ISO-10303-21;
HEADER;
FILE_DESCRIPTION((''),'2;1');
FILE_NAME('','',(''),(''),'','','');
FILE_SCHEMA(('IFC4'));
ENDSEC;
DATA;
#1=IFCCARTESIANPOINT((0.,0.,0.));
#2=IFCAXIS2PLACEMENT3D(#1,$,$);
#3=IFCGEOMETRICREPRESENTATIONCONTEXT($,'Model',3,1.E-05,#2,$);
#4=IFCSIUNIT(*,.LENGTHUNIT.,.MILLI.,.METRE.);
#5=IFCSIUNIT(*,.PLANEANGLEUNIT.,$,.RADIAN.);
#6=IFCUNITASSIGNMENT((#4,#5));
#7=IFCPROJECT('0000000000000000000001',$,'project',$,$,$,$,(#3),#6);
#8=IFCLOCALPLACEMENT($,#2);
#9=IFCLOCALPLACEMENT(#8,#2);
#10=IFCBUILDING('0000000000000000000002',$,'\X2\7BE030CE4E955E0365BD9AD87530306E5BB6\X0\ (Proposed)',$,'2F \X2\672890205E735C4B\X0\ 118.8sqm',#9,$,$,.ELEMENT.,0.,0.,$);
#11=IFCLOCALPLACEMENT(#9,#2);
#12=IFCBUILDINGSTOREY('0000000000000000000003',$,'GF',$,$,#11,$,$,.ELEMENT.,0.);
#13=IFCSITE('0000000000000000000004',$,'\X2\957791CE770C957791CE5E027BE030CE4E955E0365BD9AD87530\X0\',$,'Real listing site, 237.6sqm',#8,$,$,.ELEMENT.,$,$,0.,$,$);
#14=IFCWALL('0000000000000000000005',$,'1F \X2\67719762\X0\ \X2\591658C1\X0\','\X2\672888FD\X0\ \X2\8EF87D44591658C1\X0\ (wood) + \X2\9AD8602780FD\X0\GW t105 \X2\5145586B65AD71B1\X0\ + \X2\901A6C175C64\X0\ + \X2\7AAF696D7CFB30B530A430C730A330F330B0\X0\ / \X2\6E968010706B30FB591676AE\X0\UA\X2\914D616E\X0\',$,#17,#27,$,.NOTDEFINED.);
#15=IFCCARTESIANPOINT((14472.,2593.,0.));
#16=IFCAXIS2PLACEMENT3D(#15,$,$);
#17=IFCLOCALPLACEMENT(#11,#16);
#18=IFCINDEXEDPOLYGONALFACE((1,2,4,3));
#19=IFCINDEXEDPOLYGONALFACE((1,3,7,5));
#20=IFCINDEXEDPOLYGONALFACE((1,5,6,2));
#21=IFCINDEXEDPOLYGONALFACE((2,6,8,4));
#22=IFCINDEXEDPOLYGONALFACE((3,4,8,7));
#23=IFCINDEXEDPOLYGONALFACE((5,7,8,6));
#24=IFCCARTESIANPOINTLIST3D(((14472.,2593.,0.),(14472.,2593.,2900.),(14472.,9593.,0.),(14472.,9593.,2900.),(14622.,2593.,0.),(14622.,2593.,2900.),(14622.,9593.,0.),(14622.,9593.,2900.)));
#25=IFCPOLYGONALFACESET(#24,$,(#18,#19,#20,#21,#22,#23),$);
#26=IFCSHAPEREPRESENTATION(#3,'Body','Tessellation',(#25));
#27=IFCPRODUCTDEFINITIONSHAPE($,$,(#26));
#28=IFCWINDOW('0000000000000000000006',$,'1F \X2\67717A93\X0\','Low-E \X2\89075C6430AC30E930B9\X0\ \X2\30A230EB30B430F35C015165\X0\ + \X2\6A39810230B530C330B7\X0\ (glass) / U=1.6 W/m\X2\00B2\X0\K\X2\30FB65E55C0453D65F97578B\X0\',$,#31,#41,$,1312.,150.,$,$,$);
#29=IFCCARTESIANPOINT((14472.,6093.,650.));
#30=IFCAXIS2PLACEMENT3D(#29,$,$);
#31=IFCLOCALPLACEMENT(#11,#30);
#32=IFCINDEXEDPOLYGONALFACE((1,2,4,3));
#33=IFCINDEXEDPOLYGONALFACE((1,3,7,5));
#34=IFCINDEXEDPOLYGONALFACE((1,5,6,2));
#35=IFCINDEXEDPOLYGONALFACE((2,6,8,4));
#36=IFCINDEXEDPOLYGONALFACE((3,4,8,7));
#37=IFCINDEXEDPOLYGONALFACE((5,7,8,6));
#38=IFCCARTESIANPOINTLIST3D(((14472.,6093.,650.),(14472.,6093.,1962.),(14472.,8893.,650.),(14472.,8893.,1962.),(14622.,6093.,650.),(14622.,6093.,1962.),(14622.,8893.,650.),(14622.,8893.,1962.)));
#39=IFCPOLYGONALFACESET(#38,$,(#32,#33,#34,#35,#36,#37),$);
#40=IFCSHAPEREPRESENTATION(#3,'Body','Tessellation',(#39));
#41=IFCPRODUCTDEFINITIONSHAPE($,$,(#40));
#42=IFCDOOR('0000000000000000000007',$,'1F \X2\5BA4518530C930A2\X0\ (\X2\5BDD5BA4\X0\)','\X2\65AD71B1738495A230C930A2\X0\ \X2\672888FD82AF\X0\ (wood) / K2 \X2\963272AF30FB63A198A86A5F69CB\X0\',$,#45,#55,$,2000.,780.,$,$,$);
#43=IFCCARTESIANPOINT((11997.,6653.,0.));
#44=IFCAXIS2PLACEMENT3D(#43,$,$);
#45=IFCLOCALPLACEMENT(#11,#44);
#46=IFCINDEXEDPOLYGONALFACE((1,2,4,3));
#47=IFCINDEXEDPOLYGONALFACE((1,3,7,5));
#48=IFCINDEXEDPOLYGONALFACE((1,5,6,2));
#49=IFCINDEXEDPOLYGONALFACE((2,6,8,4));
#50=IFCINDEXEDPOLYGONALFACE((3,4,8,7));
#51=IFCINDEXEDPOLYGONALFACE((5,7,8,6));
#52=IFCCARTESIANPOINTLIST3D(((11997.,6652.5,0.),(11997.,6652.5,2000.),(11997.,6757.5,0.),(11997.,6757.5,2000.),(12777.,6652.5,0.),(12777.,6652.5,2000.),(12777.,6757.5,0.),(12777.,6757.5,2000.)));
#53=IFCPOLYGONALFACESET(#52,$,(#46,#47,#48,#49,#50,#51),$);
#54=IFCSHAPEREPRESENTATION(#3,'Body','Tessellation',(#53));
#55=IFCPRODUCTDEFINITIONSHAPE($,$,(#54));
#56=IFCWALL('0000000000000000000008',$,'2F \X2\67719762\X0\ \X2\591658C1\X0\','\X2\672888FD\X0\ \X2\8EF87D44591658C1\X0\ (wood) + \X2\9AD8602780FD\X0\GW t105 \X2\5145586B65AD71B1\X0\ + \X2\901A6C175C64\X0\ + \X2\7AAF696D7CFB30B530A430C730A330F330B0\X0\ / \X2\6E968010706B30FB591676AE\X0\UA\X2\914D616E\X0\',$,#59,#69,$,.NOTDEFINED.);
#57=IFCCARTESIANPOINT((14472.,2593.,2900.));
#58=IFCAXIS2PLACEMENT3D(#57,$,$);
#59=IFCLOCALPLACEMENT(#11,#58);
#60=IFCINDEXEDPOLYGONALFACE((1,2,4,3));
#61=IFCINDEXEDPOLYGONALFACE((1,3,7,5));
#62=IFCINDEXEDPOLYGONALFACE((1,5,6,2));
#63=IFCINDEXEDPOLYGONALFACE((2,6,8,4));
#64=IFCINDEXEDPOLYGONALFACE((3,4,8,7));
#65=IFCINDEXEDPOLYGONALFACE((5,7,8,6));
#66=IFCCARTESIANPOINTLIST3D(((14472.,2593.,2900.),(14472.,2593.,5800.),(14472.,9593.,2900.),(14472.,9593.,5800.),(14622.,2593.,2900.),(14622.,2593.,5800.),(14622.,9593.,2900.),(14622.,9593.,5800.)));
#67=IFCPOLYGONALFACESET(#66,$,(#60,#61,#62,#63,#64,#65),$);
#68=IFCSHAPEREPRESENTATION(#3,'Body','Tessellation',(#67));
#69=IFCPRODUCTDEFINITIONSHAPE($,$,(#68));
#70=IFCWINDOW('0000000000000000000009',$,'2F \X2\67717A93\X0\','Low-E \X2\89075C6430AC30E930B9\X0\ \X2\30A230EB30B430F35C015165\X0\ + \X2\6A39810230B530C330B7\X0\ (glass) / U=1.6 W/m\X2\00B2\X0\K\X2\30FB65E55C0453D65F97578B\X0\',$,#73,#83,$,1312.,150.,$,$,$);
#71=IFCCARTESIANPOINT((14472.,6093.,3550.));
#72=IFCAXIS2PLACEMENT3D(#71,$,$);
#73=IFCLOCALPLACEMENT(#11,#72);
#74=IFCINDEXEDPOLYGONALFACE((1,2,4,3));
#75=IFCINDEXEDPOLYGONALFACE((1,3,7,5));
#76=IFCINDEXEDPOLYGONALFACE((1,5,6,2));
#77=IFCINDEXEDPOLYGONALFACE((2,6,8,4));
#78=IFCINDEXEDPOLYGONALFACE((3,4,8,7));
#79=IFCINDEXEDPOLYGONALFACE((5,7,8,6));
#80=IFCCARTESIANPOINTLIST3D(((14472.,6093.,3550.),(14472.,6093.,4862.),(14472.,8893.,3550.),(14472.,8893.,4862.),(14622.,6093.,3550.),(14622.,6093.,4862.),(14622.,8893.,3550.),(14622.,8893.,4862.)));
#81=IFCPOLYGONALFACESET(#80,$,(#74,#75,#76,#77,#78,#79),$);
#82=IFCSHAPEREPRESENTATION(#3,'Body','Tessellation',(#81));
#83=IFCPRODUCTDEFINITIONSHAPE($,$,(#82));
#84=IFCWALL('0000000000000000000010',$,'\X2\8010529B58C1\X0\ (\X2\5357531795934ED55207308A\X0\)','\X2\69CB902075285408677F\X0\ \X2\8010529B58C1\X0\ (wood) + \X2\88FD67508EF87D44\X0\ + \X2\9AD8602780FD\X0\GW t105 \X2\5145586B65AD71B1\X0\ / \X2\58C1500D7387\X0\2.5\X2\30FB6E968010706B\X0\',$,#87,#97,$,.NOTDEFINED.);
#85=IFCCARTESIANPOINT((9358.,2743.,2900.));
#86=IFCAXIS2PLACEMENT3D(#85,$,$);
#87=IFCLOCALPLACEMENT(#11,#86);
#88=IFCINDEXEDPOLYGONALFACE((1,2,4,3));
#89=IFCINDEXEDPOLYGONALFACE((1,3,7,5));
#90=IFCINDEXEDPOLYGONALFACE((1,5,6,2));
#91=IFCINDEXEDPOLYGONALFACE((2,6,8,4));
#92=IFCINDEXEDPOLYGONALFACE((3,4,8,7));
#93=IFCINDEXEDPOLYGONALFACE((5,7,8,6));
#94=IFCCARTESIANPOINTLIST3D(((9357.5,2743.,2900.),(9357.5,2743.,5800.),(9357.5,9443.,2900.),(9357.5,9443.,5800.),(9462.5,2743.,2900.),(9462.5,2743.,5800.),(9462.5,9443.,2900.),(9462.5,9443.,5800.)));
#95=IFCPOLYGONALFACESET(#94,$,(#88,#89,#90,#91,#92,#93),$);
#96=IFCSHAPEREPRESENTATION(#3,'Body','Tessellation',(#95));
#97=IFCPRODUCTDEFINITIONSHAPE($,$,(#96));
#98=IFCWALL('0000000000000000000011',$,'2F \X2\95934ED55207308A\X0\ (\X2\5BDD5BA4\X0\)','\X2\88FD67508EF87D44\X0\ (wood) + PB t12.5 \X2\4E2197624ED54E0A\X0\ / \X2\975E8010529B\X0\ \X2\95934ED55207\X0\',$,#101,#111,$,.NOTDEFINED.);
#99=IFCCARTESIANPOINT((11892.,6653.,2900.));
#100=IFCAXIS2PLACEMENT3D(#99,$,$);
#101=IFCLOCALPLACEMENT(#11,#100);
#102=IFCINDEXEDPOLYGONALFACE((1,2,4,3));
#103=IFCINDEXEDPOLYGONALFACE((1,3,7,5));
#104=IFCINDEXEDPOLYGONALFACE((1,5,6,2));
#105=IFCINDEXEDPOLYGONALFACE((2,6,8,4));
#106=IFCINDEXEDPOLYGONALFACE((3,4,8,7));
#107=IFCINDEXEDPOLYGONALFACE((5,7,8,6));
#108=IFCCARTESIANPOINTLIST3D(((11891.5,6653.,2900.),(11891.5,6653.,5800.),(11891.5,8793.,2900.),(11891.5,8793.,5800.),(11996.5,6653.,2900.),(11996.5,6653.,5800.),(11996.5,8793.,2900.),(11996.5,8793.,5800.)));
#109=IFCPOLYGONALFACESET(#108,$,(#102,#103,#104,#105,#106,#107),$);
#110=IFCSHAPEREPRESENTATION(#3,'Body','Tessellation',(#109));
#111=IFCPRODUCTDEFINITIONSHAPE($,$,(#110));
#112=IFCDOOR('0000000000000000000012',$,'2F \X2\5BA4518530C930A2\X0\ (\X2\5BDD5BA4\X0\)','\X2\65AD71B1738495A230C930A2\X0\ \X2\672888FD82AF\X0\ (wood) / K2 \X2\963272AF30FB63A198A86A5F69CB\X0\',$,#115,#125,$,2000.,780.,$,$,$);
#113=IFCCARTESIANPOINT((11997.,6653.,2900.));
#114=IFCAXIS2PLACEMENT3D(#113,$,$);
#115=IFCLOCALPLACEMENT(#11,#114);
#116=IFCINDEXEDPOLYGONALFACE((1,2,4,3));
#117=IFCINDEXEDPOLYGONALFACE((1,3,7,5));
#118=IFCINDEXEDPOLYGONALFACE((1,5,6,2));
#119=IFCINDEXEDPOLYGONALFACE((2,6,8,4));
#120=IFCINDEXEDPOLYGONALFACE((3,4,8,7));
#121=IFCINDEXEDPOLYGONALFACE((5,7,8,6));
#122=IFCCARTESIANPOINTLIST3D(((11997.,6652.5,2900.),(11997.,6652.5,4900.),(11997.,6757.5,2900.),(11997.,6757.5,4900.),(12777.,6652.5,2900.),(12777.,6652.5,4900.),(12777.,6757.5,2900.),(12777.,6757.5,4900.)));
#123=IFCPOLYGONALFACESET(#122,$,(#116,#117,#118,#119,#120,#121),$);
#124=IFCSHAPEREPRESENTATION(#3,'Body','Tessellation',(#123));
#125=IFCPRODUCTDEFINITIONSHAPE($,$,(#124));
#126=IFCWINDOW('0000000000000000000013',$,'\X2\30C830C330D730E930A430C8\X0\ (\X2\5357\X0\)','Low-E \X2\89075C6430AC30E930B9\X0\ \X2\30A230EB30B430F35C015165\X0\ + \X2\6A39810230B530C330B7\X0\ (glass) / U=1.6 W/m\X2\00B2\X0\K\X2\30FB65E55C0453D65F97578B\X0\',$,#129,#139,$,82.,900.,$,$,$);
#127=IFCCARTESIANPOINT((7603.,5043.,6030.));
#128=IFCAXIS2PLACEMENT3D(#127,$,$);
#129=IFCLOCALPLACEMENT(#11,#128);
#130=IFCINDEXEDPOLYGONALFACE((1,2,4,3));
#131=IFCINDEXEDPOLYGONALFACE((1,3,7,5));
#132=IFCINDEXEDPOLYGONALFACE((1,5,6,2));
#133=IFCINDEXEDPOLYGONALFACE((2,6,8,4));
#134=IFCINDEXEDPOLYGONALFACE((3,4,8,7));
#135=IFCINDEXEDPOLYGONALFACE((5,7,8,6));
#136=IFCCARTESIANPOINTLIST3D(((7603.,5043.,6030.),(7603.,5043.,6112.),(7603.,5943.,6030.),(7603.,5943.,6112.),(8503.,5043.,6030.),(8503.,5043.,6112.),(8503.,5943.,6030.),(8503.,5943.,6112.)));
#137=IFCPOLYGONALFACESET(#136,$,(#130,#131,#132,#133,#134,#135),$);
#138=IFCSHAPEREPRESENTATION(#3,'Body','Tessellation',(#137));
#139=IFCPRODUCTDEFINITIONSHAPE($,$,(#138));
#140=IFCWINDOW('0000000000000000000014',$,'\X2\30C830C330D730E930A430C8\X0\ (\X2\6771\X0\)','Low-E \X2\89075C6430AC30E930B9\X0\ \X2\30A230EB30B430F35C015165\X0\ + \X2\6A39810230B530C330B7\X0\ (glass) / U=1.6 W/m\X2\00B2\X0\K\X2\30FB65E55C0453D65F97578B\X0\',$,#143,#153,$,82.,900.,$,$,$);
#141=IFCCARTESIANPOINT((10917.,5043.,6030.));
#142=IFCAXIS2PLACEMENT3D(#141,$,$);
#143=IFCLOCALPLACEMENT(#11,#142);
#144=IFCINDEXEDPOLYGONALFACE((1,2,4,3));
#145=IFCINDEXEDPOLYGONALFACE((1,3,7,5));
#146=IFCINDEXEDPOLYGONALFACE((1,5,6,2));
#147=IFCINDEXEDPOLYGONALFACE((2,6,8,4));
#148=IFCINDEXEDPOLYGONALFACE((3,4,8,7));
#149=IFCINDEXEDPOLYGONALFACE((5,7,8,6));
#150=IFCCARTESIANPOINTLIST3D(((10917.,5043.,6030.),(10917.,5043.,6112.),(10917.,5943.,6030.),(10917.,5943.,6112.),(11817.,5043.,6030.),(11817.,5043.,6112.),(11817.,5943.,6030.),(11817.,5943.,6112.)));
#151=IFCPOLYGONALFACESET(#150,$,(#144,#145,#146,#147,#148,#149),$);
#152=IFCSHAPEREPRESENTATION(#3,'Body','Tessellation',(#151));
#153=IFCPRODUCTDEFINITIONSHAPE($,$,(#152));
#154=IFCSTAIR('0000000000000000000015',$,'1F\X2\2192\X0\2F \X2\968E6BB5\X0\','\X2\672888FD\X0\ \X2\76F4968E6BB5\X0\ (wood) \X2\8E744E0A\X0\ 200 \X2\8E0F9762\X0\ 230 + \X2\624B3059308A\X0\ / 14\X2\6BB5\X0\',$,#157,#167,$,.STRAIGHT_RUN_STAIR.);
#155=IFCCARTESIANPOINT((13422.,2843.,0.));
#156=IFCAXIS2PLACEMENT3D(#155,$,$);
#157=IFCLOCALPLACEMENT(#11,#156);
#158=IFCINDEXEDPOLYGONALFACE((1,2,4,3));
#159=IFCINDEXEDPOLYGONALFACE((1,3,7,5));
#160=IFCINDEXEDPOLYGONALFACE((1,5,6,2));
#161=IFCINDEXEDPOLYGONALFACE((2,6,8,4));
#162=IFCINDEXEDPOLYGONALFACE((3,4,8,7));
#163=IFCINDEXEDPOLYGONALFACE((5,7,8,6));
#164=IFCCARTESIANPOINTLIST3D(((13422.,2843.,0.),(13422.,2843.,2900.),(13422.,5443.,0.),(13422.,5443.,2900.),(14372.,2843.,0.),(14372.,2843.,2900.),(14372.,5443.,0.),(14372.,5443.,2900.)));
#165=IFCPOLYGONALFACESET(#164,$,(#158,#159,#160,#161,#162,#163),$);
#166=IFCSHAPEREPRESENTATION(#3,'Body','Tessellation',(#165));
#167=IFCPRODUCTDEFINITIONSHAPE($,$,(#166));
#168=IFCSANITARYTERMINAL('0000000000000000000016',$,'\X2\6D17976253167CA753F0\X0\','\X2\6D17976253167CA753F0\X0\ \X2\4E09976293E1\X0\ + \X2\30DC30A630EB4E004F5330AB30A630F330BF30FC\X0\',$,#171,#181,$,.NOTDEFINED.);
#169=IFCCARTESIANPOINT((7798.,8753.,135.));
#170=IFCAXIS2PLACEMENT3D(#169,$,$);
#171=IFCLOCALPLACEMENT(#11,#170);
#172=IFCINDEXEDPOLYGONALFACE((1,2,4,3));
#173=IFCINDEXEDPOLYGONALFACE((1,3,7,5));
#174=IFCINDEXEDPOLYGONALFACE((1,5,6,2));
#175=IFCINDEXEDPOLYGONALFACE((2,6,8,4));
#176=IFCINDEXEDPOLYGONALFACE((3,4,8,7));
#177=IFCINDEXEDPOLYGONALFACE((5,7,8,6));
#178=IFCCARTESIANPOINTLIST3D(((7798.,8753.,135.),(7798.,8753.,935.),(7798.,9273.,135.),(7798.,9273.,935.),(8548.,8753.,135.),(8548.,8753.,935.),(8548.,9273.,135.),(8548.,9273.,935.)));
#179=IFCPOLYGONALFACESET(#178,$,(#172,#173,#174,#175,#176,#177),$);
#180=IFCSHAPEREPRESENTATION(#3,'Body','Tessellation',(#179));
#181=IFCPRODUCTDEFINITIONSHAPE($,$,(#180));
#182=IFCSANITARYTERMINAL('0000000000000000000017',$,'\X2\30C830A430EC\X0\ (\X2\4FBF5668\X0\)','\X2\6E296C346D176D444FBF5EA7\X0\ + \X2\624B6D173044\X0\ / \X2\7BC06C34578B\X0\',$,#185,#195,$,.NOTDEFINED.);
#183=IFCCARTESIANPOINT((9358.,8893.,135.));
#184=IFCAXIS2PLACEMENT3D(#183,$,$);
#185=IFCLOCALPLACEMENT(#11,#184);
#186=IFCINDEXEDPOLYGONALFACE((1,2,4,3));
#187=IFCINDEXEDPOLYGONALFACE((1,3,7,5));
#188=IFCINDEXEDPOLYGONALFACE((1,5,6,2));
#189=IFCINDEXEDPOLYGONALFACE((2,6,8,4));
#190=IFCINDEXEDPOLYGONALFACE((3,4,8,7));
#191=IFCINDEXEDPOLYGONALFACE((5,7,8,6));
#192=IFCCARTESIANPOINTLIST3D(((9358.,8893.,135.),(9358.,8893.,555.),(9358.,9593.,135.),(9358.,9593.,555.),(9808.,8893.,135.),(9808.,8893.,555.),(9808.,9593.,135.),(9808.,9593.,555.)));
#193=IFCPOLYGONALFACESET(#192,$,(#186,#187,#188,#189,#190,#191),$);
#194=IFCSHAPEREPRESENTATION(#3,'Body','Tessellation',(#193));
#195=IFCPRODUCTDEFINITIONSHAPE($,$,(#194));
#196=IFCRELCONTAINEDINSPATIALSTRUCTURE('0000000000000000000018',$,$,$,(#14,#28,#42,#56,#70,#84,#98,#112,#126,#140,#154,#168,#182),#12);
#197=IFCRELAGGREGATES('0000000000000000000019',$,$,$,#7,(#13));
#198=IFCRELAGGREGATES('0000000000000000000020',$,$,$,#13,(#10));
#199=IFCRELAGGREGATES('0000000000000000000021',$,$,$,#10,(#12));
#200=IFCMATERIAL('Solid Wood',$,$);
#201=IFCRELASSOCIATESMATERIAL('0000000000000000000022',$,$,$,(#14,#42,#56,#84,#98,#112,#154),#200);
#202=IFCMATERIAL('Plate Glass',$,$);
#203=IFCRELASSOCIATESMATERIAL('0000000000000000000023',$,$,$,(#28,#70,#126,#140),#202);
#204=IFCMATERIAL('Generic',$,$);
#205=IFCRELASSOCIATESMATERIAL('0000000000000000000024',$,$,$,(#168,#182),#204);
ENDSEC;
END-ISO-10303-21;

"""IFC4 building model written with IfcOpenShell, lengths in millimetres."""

from ifc_helpers import new_model, si_unit, frame, frame_2d, origin, place, context, project, spatial, rectangle, extrude, material, element, fill, save


model = new_model("IFC4")

# Units and contexts
model_context = context("Model", 3, precision=1e-05, world=origin())
ifc_project = project(units=[si_unit("LENGTHUNIT", "METRE", prefix="MILLI"), si_unit("PLANEANGLEUNIT", "RADIAN")], contexts=[model_context])

# Site, building, storey
site_placement = place(None, origin())
site = spatial("IfcSite", under=ifc_project, at=site_placement, Name="長野県長野市篠ノ井布施高田", ObjectType="Real listing site, 237.6sqm", CompositionType="ELEMENT", RefElevation=0.0)
building_placement = place(site_placement, origin())
building = spatial("IfcBuilding", under=site, at=building_placement, Name="篠ノ井布施高田の家 (Proposed)", ObjectType="2F 木造平屋 118.8sqm", CompositionType="ELEMENT", ElevationOfRefHeight=0.0, ElevationOfTerrain=0.0)
storey_placement = place(building_placement, origin())
storey = spatial("IfcBuildingStorey", under=building, at=storey_placement, Name="GF", CompositionType="ELEMENT", Elevation=0.0)

# Wall, opening, window
ifc_material_1 = material(Name="Solid Wood")
wall_1_placement = place(storey_placement, frame((14472.0, 2593.0, 0.0)))
wall_1 = element("IfcWall", 1, at=wall_1_placement, inside=storey, material=ifc_material_1, Name="1F 東面 外壁", Description="木製 軸組外壁 (wood) + 高性能GW t105 充填断熱 + 通気層 + 窯業系サイディング / 準耐火・外皮UA配慮", PredefinedType="NOTDEFINED", context=model_context, shape_type="SweptSolid", body=[
    extrude(rectangle(XDim=150.0, YDim=7000.0, at=frame_2d((75.0, 3500.0))), frame((14472.0, 2593.0, 0.0)), (0.0, 0.0, 1.0), 2900.0),
])
opening_1_placement = place(storey_placement, frame((14472.0, 6093.0, 650.0)))
opening_1 = element("IfcOpeningElement", 2, at=opening_1_placement, cuts=wall_1, PredefinedType="NOTDEFINED", context=model_context, shape_type="SweptSolid", body=[
    extrude(rectangle(XDim=150.0, YDim=2800.0, at=frame_2d((75.0, 1400.0))), frame((14472.0, 6093.0, 650.0)), (0.0, 0.0, 1.0), 1312.0),
])
ifc_material_2 = material(Name="Plate Glass")
window_1_placement = place(storey_placement, frame((14472.0, 6093.0, 650.0)))
window_1 = element("IfcWindow", 3, at=window_1_placement, inside=storey, material=ifc_material_2, Name="1F 東窓", Description="Low-E 複層ガラス アルゴン封入 + 樹脂サッシ (glass) / U=1.6 W/m²K・日射取得型", OverallHeight=1312.0, OverallWidth=150.0, context=model_context, shape_type="SweptSolid", body=[
    extrude(rectangle(XDim=150.0, YDim=2800.0, at=frame_2d((75.0, 1400.0))), frame((14472.0, 6093.0, 650.0)), (0.0, 0.0, 1.0), 1312.0),
])
fill(opening_1, window_1)

# Door
door_1_placement = place(storey_placement, frame((11997.0, 6653.0, 0.0)))
element("IfcDoor", 4, at=door_1_placement, inside=storey, material=ifc_material_1, Name="1F 室内ドア (寝室)", Description="断熱玄関ドア 木製芯 (wood) / K2 防犯・採風機構", OverallHeight=2000.0, OverallWidth=780.0, context=model_context, shape_type="SweptSolid", body=[
    extrude(rectangle(XDim=780.0, YDim=105.0, at=frame_2d((390.0, 52.0))), frame((11997.0, 6653.0, 0.0)), (0.0, 0.0, 1.0), 2000.0),
])

# Wall, opening, window
wall_2_placement = place(storey_placement, frame((14472.0, 2593.0, 2900.0)))
wall_2 = element("IfcWall", 5, at=wall_2_placement, inside=storey, material=ifc_material_1, Name="2F 東面 外壁", Description="木製 軸組外壁 (wood) + 高性能GW t105 充填断熱 + 通気層 + 窯業系サイディング / 準耐火・外皮UA配慮", PredefinedType="NOTDEFINED", context=model_context, shape_type="SweptSolid", body=[
    extrude(rectangle(XDim=150.0, YDim=7000.0, at=frame_2d((75.0, 3500.0))), frame((14472.0, 2593.0, 2900.0)), (0.0, 0.0, 1.0), 2900.0),
])
opening_2_placement = place(storey_placement, frame((14472.0, 6093.0, 3550.0)))
opening_2 = element("IfcOpeningElement", 6, at=opening_2_placement, cuts=wall_2, PredefinedType="NOTDEFINED", context=model_context, shape_type="SweptSolid", body=[
    extrude(rectangle(XDim=150.0, YDim=2800.0, at=frame_2d((75.0, 1400.0))), frame((14472.0, 6093.0, 3550.0)), (0.0, 0.0, 1.0), 1312.0),
])
window_2_placement = place(storey_placement, frame((14472.0, 6093.0, 3550.0)))
window_2 = element("IfcWindow", 7, at=window_2_placement, inside=storey, material=ifc_material_2, Name="2F 東窓", Description="Low-E 複層ガラス アルゴン封入 + 樹脂サッシ (glass) / U=1.6 W/m²K・日射取得型", OverallHeight=1312.0, OverallWidth=150.0, context=model_context, shape_type="SweptSolid", body=[
    extrude(rectangle(XDim=150.0, YDim=2800.0, at=frame_2d((75.0, 1400.0))), frame((14472.0, 6093.0, 3550.0)), (0.0, 0.0, 1.0), 1312.0),
])
fill(opening_2, window_2)

# Walls
wall_3_placement = place(storey_placement, frame((9358.0, 2743.0, 2900.0)))
element("IfcWall", 8, at=wall_3_placement, inside=storey, material=ifc_material_1, Name="耐力壁 (南北間仕切り)", Description="構造用合板 耐力壁 (wood) + 製材軸組 + 高性能GW t105 充填断熱 / 壁倍率2.5・準耐火", PredefinedType="NOTDEFINED", context=model_context, shape_type="SweptSolid", body=[
    extrude(rectangle(XDim=105.0, YDim=6700.0, at=frame_2d((52.0, 3350.0))), frame((9358.0, 2743.0, 2900.0)), (0.0, 0.0, 1.0), 2900.0),
])
wall_4_placement = place(storey_placement, frame((11892.0, 6653.0, 2900.0)))
element("IfcWall", 9, at=wall_4_placement, inside=storey, material=ifc_material_1, Name="2F 間仕切り (寝室)", Description="製材軸組 (wood) + PB t12.5 両面仕上 / 非耐力 間仕切", PredefinedType="NOTDEFINED", context=model_context, shape_type="SweptSolid", body=[
    extrude(rectangle(XDim=105.0, YDim=2140.0, at=frame_2d((52.0, 1070.0))), frame((11892.0, 6653.0, 2900.0)), (0.0, 0.0, 1.0), 2900.0),
])

# Door
door_2_placement = place(storey_placement, frame((11997.0, 6653.0, 2900.0)))
element("IfcDoor", 10, at=door_2_placement, inside=storey, material=ifc_material_1, Name="2F 室内ドア (寝室)", Description="断熱玄関ドア 木製芯 (wood) / K2 防犯・採風機構", OverallHeight=2000.0, OverallWidth=780.0, context=model_context, shape_type="SweptSolid", body=[
    extrude(rectangle(XDim=780.0, YDim=105.0, at=frame_2d((390.0, 52.0))), frame((11997.0, 6653.0, 2900.0)), (0.0, 0.0, 1.0), 2000.0),
])

# Windows
window_3_placement = place(storey_placement, frame((7603.0, 5043.0, 6030.0)))
element("IfcWindow", 11, at=window_3_placement, inside=storey, material=ifc_material_2, Name="トップライト (南)", Description="Low-E 複層ガラス アルゴン封入 + 樹脂サッシ (glass) / U=1.6 W/m²K・日射取得型", OverallHeight=82.0, OverallWidth=900.0, context=model_context, shape_type="SweptSolid", body=[
    extrude(rectangle(XDim=900.0, YDim=900.0, at=frame_2d((450.0, 450.0))), frame((7603.0, 5043.0, 6030.0)), (0.0, 0.0, 1.0), 82.0),
])
window_4_placement = place(storey_placement, frame((10917.0, 5043.0, 6030.0)))
element("IfcWindow", 12, at=window_4_placement, inside=storey, material=ifc_material_2, Name="トップライト (東)", Description="Low-E 複層ガラス アルゴン封入 + 樹脂サッシ (glass) / U=1.6 W/m²K・日射取得型", OverallHeight=82.0, OverallWidth=900.0, context=model_context, shape_type="SweptSolid", body=[
    extrude(rectangle(XDim=900.0, YDim=900.0, at=frame_2d((450.0, 450.0))), frame((10917.0, 5043.0, 6030.0)), (0.0, 0.0, 1.0), 82.0),
])

# Stair
stair_placement = place(storey_placement, frame((13422.0, 2843.0, 0.0)))
element("IfcStair", 13, at=stair_placement, inside=storey, material=ifc_material_1, Name="1F→2F 階段", Description="木製 直階段 (wood) 蹴上 200 踏面 230 + 手すり / 14段", PredefinedType="STRAIGHT_RUN_STAIR", context=model_context, shape_type="SweptSolid", body=[
    extrude(rectangle(XDim=950.0, YDim=2600.0, at=frame_2d((475.0, 1300.0))), frame((13422.0, 2843.0, 0.0)), (0.0, 0.0, 1.0), 2900.0),
])

# Sanitary terminals
ifc_material_3 = material(Name="Generic")
sanitary_terminal_1_placement = place(storey_placement, frame((7798.0, 8753.0, 135.0)))
element("IfcSanitaryTerminal", 14, at=sanitary_terminal_1_placement, inside=storey, material=ifc_material_3, Name="洗面化粧台", Description="洗面化粧台 三面鏡 + ボウル一体カウンター", PredefinedType="NOTDEFINED", context=model_context, shape_type="SweptSolid", body=[
    extrude(rectangle(XDim=750.0, YDim=520.0, at=frame_2d((375.0, 260.0))), frame((7798.0, 8753.0, 135.0)), (0.0, 0.0, 1.0), 800.0),
])
sanitary_terminal_2_placement = place(storey_placement, frame((9358.0, 8893.0, 135.0)))
element("IfcSanitaryTerminal", 15, at=sanitary_terminal_2_placement, inside=storey, material=ifc_material_3, Name="トイレ (便器)", Description="温水洗浄便座 + 手洗い / 節水型", PredefinedType="NOTDEFINED", context=model_context, shape_type="SweptSolid", body=[
    extrude(rectangle(XDim=450.0, YDim=700.0, at=frame_2d((225.0, 350.0))), frame((9358.0, 8893.0, 135.0)), (0.0, 0.0, 1.0), 420.0),
])

save(model, "model.ifc")
